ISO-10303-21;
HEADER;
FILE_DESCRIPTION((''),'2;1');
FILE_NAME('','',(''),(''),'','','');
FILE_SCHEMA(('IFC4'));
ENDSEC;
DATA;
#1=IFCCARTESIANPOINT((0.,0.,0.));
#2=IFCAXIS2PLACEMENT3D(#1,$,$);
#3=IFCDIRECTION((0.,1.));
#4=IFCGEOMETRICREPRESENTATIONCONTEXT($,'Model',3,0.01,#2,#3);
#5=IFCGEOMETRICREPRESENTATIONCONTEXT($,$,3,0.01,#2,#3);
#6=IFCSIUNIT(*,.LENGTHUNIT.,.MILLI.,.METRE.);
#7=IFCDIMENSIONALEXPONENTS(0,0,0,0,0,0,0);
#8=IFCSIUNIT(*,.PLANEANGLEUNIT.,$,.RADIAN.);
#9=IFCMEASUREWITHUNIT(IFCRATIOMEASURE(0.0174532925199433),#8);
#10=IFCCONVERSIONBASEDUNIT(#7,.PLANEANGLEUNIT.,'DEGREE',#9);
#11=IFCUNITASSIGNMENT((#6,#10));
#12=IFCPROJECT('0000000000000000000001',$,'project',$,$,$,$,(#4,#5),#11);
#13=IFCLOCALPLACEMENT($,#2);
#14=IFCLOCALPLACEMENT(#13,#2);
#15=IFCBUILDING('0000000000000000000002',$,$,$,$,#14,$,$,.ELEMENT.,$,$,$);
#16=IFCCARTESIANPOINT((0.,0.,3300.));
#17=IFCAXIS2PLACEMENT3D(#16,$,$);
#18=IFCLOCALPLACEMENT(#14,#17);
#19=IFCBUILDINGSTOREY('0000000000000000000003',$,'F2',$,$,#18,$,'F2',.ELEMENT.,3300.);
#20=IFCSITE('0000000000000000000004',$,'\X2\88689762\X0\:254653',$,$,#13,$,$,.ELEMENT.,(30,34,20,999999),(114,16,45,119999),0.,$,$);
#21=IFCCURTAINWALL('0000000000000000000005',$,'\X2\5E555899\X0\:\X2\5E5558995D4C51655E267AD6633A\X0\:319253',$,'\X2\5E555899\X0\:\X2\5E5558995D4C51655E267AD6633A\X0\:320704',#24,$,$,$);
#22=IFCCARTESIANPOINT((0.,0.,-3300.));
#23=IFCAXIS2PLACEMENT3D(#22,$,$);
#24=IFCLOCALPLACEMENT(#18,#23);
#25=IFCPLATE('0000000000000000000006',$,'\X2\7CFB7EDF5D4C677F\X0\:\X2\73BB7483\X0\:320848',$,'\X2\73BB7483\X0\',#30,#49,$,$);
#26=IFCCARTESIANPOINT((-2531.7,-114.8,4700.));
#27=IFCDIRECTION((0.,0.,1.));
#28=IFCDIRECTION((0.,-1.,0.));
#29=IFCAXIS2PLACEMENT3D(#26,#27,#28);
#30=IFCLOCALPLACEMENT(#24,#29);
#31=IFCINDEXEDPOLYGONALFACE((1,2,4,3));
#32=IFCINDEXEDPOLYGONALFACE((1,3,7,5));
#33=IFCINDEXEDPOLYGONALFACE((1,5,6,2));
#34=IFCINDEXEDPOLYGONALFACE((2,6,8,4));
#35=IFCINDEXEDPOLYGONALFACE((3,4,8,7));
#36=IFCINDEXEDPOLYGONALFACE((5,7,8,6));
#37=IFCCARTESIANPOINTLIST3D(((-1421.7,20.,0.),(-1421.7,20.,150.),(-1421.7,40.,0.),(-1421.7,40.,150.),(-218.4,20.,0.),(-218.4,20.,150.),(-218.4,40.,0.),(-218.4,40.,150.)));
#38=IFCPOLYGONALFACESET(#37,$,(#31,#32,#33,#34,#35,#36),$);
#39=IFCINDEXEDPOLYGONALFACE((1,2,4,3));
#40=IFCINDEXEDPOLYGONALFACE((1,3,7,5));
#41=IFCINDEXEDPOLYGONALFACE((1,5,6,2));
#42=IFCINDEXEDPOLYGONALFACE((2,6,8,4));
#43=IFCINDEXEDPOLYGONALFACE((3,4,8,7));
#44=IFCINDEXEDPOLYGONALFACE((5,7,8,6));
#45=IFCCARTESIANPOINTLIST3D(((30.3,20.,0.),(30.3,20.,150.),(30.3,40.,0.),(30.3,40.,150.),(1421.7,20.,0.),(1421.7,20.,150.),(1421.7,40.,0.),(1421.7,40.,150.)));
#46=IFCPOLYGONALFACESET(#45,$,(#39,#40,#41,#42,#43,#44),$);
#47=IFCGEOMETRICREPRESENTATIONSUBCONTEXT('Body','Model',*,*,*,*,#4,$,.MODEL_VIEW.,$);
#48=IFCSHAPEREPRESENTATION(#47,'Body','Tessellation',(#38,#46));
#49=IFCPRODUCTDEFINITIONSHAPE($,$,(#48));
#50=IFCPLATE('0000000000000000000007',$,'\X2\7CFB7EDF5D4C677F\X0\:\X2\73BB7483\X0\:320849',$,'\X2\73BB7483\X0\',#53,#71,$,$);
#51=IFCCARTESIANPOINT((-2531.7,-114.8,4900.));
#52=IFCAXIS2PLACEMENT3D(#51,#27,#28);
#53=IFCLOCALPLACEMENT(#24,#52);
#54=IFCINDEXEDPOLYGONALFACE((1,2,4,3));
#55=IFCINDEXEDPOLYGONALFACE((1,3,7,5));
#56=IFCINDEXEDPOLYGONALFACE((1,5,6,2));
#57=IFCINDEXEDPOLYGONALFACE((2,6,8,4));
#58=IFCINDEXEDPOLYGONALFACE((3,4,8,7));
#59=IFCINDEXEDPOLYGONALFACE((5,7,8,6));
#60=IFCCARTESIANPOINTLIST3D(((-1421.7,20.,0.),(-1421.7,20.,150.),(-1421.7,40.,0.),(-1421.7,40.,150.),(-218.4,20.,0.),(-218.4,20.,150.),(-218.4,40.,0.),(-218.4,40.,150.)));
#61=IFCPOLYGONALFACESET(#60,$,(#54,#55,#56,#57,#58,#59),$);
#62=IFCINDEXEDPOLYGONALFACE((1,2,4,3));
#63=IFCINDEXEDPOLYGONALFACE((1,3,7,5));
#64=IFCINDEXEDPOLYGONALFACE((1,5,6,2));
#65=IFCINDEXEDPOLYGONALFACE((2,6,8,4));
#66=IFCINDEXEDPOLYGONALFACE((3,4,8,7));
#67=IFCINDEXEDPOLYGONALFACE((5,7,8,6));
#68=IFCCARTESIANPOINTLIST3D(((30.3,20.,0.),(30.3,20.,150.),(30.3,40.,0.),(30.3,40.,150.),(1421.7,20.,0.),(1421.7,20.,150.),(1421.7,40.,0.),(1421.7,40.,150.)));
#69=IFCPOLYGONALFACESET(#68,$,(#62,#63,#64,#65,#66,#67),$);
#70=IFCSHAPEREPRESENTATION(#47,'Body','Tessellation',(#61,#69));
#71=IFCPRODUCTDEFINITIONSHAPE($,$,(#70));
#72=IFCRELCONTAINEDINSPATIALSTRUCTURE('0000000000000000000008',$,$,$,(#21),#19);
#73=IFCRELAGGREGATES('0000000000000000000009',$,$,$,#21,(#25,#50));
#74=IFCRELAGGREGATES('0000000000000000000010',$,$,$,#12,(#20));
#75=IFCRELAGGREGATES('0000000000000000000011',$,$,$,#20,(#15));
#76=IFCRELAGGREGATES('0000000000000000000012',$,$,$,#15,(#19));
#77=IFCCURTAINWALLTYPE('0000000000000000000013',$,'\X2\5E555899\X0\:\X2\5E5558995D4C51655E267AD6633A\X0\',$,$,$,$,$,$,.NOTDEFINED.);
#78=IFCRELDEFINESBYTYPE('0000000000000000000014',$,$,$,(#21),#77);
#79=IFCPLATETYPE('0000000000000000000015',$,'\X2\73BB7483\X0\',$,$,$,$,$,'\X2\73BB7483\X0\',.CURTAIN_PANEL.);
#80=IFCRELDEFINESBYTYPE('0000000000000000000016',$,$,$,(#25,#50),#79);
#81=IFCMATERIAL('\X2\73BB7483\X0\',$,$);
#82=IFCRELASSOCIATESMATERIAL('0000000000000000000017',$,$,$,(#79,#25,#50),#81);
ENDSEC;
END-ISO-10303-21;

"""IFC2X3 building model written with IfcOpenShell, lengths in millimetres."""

from ifc_helpers import new_model, entity, si_unit, converted_unit, direction, frame, frame_2d, origin, place, context, subcontext, project, spatial, rectangle, extrude, source, transform, mapped, material, type_object, type_shapes, element, aggregate, save


model = new_model("IFC2X3")

# Units and contexts
model_context = context("Model", 3, precision=0.01, world=origin(), true_north=direction((0.0, 1.0)))
context_of_model = context(None, 3, precision=0.01, world=origin(), true_north=direction((0.0, 1.0)))
body_context = subcontext(model_context, "Body", "Model", "MODEL_VIEW")
ifc_project = project(units=[si_unit("LENGTHUNIT", "METRE", prefix="MILLI"), converted_unit("PLANEANGLEUNIT", "DEGREE", entity("IfcRatioMeasure", 0.0174532925199433), si_unit("PLANEANGLEUNIT", "RADIAN"), dimensions=[0, 0, 0, 0, 0, 0, 0])], contexts=[model_context, context_of_model])

# Site, building, storey
site_placement = place(None, origin())
site = spatial("IfcSite", under=ifc_project, at=site_placement, Name="表面:254653", CompositionType="ELEMENT", RefLatitude=(30, 34, 20, 999999), RefLongitude=(114, 16, 45, 119999), RefElevation=0.0)
building_placement = place(site_placement, origin())
building = spatial("IfcBuilding", under=site, at=building_placement, CompositionType="ELEMENT")
storey_placement = place(building_placement, frame((0.0, 0.0, 3300.0)))
storey = spatial("IfcBuildingStorey", under=building, at=storey_placement, Name="F2", LongName="F2", CompositionType="ELEMENT", Elevation=3300.0)

# Curtain wall, plates
curtain_wall_type = type_object("IfcCurtainWallType", Name="幕墙:幕墙嵌入带竖挺", PredefinedType="NOTDEFINED")
curtain_wall_placement = place(storey_placement, frame((0.0, 0.0, -3300.0)))
curtain_wall = element("IfcCurtainWall", 1, at=curtain_wall_placement, inside=storey, type_object=curtain_wall_type, Name="幕墙:幕墙嵌入带竖挺:319253", ObjectType="幕墙:幕墙嵌入带竖挺:320704")
ifc_material_1 = material(Name="玻璃")
plate_type_1 = type_object("IfcPlateType", Name="玻璃", ElementType="玻璃", PredefinedType="CURTAIN_PANEL", material=ifc_material_1)
shared_shape_1 = source(origin(), body_context, "Body", "SweptSolid", [
    extrude(rectangle(XDim=20.0, YDim=1203.3, at=frame_2d((0.0, 0.0), x_axis=(1.0, 0.0))), frame((-820.0, 30.0, 0.0), z_axis=(0.0, 0.0, 1.0), x_axis=(0.0, 1.0, 0.0)), (0.0, 0.0, 1.0), 150.0),
    extrude(rectangle(XDim=20.0, YDim=1391.3, at=frame_2d((0.0, 0.0), x_axis=(1.0, 0.0))), frame((726.0, 30.0, 0.0), z_axis=(0.0, 0.0, 1.0), x_axis=(0.0, 1.0, 0.0)), (0.0, 0.0, 1.0), 150.0),
])
type_shapes(plate_type_1, [shared_shape_1])
plate_1_placement = place(curtain_wall_placement, frame((-2531.7, -114.8, 4700.0), z_axis=(0.0, 0.0, 1.0), x_axis=(0.0, -1.0, 0.0)))
plate_1 = element("IfcPlate", 2, at=plate_1_placement, type_object=plate_type_1, material=ifc_material_1, Name="系统嵌板:玻璃:320848", ObjectType="玻璃", context=body_context, shape_type="MappedRepresentation", body=[
    mapped(shared_shape_1, transform((0.0, 0.0, 0.0), scale=1.0)),
])
plate_2_placement = place(curtain_wall_placement, frame((-2531.7, -114.8, 4900.0), z_axis=(0.0, 0.0, 1.0), x_axis=(0.0, -1.0, 0.0)))
plate_2 = element("IfcPlate", 3, at=plate_2_placement, type_object=plate_type_1, material=ifc_material_1, Name="系统嵌板:玻璃:320849", ObjectType="玻璃", context=body_context, shape_type="MappedRepresentation", body=[
    mapped(shared_shape_1, transform((0.0, 0.0, 0.0), scale=1.0)),
])
aggregate(curtain_wall, [plate_1, plate_2])

save(model, "model.ifc")
